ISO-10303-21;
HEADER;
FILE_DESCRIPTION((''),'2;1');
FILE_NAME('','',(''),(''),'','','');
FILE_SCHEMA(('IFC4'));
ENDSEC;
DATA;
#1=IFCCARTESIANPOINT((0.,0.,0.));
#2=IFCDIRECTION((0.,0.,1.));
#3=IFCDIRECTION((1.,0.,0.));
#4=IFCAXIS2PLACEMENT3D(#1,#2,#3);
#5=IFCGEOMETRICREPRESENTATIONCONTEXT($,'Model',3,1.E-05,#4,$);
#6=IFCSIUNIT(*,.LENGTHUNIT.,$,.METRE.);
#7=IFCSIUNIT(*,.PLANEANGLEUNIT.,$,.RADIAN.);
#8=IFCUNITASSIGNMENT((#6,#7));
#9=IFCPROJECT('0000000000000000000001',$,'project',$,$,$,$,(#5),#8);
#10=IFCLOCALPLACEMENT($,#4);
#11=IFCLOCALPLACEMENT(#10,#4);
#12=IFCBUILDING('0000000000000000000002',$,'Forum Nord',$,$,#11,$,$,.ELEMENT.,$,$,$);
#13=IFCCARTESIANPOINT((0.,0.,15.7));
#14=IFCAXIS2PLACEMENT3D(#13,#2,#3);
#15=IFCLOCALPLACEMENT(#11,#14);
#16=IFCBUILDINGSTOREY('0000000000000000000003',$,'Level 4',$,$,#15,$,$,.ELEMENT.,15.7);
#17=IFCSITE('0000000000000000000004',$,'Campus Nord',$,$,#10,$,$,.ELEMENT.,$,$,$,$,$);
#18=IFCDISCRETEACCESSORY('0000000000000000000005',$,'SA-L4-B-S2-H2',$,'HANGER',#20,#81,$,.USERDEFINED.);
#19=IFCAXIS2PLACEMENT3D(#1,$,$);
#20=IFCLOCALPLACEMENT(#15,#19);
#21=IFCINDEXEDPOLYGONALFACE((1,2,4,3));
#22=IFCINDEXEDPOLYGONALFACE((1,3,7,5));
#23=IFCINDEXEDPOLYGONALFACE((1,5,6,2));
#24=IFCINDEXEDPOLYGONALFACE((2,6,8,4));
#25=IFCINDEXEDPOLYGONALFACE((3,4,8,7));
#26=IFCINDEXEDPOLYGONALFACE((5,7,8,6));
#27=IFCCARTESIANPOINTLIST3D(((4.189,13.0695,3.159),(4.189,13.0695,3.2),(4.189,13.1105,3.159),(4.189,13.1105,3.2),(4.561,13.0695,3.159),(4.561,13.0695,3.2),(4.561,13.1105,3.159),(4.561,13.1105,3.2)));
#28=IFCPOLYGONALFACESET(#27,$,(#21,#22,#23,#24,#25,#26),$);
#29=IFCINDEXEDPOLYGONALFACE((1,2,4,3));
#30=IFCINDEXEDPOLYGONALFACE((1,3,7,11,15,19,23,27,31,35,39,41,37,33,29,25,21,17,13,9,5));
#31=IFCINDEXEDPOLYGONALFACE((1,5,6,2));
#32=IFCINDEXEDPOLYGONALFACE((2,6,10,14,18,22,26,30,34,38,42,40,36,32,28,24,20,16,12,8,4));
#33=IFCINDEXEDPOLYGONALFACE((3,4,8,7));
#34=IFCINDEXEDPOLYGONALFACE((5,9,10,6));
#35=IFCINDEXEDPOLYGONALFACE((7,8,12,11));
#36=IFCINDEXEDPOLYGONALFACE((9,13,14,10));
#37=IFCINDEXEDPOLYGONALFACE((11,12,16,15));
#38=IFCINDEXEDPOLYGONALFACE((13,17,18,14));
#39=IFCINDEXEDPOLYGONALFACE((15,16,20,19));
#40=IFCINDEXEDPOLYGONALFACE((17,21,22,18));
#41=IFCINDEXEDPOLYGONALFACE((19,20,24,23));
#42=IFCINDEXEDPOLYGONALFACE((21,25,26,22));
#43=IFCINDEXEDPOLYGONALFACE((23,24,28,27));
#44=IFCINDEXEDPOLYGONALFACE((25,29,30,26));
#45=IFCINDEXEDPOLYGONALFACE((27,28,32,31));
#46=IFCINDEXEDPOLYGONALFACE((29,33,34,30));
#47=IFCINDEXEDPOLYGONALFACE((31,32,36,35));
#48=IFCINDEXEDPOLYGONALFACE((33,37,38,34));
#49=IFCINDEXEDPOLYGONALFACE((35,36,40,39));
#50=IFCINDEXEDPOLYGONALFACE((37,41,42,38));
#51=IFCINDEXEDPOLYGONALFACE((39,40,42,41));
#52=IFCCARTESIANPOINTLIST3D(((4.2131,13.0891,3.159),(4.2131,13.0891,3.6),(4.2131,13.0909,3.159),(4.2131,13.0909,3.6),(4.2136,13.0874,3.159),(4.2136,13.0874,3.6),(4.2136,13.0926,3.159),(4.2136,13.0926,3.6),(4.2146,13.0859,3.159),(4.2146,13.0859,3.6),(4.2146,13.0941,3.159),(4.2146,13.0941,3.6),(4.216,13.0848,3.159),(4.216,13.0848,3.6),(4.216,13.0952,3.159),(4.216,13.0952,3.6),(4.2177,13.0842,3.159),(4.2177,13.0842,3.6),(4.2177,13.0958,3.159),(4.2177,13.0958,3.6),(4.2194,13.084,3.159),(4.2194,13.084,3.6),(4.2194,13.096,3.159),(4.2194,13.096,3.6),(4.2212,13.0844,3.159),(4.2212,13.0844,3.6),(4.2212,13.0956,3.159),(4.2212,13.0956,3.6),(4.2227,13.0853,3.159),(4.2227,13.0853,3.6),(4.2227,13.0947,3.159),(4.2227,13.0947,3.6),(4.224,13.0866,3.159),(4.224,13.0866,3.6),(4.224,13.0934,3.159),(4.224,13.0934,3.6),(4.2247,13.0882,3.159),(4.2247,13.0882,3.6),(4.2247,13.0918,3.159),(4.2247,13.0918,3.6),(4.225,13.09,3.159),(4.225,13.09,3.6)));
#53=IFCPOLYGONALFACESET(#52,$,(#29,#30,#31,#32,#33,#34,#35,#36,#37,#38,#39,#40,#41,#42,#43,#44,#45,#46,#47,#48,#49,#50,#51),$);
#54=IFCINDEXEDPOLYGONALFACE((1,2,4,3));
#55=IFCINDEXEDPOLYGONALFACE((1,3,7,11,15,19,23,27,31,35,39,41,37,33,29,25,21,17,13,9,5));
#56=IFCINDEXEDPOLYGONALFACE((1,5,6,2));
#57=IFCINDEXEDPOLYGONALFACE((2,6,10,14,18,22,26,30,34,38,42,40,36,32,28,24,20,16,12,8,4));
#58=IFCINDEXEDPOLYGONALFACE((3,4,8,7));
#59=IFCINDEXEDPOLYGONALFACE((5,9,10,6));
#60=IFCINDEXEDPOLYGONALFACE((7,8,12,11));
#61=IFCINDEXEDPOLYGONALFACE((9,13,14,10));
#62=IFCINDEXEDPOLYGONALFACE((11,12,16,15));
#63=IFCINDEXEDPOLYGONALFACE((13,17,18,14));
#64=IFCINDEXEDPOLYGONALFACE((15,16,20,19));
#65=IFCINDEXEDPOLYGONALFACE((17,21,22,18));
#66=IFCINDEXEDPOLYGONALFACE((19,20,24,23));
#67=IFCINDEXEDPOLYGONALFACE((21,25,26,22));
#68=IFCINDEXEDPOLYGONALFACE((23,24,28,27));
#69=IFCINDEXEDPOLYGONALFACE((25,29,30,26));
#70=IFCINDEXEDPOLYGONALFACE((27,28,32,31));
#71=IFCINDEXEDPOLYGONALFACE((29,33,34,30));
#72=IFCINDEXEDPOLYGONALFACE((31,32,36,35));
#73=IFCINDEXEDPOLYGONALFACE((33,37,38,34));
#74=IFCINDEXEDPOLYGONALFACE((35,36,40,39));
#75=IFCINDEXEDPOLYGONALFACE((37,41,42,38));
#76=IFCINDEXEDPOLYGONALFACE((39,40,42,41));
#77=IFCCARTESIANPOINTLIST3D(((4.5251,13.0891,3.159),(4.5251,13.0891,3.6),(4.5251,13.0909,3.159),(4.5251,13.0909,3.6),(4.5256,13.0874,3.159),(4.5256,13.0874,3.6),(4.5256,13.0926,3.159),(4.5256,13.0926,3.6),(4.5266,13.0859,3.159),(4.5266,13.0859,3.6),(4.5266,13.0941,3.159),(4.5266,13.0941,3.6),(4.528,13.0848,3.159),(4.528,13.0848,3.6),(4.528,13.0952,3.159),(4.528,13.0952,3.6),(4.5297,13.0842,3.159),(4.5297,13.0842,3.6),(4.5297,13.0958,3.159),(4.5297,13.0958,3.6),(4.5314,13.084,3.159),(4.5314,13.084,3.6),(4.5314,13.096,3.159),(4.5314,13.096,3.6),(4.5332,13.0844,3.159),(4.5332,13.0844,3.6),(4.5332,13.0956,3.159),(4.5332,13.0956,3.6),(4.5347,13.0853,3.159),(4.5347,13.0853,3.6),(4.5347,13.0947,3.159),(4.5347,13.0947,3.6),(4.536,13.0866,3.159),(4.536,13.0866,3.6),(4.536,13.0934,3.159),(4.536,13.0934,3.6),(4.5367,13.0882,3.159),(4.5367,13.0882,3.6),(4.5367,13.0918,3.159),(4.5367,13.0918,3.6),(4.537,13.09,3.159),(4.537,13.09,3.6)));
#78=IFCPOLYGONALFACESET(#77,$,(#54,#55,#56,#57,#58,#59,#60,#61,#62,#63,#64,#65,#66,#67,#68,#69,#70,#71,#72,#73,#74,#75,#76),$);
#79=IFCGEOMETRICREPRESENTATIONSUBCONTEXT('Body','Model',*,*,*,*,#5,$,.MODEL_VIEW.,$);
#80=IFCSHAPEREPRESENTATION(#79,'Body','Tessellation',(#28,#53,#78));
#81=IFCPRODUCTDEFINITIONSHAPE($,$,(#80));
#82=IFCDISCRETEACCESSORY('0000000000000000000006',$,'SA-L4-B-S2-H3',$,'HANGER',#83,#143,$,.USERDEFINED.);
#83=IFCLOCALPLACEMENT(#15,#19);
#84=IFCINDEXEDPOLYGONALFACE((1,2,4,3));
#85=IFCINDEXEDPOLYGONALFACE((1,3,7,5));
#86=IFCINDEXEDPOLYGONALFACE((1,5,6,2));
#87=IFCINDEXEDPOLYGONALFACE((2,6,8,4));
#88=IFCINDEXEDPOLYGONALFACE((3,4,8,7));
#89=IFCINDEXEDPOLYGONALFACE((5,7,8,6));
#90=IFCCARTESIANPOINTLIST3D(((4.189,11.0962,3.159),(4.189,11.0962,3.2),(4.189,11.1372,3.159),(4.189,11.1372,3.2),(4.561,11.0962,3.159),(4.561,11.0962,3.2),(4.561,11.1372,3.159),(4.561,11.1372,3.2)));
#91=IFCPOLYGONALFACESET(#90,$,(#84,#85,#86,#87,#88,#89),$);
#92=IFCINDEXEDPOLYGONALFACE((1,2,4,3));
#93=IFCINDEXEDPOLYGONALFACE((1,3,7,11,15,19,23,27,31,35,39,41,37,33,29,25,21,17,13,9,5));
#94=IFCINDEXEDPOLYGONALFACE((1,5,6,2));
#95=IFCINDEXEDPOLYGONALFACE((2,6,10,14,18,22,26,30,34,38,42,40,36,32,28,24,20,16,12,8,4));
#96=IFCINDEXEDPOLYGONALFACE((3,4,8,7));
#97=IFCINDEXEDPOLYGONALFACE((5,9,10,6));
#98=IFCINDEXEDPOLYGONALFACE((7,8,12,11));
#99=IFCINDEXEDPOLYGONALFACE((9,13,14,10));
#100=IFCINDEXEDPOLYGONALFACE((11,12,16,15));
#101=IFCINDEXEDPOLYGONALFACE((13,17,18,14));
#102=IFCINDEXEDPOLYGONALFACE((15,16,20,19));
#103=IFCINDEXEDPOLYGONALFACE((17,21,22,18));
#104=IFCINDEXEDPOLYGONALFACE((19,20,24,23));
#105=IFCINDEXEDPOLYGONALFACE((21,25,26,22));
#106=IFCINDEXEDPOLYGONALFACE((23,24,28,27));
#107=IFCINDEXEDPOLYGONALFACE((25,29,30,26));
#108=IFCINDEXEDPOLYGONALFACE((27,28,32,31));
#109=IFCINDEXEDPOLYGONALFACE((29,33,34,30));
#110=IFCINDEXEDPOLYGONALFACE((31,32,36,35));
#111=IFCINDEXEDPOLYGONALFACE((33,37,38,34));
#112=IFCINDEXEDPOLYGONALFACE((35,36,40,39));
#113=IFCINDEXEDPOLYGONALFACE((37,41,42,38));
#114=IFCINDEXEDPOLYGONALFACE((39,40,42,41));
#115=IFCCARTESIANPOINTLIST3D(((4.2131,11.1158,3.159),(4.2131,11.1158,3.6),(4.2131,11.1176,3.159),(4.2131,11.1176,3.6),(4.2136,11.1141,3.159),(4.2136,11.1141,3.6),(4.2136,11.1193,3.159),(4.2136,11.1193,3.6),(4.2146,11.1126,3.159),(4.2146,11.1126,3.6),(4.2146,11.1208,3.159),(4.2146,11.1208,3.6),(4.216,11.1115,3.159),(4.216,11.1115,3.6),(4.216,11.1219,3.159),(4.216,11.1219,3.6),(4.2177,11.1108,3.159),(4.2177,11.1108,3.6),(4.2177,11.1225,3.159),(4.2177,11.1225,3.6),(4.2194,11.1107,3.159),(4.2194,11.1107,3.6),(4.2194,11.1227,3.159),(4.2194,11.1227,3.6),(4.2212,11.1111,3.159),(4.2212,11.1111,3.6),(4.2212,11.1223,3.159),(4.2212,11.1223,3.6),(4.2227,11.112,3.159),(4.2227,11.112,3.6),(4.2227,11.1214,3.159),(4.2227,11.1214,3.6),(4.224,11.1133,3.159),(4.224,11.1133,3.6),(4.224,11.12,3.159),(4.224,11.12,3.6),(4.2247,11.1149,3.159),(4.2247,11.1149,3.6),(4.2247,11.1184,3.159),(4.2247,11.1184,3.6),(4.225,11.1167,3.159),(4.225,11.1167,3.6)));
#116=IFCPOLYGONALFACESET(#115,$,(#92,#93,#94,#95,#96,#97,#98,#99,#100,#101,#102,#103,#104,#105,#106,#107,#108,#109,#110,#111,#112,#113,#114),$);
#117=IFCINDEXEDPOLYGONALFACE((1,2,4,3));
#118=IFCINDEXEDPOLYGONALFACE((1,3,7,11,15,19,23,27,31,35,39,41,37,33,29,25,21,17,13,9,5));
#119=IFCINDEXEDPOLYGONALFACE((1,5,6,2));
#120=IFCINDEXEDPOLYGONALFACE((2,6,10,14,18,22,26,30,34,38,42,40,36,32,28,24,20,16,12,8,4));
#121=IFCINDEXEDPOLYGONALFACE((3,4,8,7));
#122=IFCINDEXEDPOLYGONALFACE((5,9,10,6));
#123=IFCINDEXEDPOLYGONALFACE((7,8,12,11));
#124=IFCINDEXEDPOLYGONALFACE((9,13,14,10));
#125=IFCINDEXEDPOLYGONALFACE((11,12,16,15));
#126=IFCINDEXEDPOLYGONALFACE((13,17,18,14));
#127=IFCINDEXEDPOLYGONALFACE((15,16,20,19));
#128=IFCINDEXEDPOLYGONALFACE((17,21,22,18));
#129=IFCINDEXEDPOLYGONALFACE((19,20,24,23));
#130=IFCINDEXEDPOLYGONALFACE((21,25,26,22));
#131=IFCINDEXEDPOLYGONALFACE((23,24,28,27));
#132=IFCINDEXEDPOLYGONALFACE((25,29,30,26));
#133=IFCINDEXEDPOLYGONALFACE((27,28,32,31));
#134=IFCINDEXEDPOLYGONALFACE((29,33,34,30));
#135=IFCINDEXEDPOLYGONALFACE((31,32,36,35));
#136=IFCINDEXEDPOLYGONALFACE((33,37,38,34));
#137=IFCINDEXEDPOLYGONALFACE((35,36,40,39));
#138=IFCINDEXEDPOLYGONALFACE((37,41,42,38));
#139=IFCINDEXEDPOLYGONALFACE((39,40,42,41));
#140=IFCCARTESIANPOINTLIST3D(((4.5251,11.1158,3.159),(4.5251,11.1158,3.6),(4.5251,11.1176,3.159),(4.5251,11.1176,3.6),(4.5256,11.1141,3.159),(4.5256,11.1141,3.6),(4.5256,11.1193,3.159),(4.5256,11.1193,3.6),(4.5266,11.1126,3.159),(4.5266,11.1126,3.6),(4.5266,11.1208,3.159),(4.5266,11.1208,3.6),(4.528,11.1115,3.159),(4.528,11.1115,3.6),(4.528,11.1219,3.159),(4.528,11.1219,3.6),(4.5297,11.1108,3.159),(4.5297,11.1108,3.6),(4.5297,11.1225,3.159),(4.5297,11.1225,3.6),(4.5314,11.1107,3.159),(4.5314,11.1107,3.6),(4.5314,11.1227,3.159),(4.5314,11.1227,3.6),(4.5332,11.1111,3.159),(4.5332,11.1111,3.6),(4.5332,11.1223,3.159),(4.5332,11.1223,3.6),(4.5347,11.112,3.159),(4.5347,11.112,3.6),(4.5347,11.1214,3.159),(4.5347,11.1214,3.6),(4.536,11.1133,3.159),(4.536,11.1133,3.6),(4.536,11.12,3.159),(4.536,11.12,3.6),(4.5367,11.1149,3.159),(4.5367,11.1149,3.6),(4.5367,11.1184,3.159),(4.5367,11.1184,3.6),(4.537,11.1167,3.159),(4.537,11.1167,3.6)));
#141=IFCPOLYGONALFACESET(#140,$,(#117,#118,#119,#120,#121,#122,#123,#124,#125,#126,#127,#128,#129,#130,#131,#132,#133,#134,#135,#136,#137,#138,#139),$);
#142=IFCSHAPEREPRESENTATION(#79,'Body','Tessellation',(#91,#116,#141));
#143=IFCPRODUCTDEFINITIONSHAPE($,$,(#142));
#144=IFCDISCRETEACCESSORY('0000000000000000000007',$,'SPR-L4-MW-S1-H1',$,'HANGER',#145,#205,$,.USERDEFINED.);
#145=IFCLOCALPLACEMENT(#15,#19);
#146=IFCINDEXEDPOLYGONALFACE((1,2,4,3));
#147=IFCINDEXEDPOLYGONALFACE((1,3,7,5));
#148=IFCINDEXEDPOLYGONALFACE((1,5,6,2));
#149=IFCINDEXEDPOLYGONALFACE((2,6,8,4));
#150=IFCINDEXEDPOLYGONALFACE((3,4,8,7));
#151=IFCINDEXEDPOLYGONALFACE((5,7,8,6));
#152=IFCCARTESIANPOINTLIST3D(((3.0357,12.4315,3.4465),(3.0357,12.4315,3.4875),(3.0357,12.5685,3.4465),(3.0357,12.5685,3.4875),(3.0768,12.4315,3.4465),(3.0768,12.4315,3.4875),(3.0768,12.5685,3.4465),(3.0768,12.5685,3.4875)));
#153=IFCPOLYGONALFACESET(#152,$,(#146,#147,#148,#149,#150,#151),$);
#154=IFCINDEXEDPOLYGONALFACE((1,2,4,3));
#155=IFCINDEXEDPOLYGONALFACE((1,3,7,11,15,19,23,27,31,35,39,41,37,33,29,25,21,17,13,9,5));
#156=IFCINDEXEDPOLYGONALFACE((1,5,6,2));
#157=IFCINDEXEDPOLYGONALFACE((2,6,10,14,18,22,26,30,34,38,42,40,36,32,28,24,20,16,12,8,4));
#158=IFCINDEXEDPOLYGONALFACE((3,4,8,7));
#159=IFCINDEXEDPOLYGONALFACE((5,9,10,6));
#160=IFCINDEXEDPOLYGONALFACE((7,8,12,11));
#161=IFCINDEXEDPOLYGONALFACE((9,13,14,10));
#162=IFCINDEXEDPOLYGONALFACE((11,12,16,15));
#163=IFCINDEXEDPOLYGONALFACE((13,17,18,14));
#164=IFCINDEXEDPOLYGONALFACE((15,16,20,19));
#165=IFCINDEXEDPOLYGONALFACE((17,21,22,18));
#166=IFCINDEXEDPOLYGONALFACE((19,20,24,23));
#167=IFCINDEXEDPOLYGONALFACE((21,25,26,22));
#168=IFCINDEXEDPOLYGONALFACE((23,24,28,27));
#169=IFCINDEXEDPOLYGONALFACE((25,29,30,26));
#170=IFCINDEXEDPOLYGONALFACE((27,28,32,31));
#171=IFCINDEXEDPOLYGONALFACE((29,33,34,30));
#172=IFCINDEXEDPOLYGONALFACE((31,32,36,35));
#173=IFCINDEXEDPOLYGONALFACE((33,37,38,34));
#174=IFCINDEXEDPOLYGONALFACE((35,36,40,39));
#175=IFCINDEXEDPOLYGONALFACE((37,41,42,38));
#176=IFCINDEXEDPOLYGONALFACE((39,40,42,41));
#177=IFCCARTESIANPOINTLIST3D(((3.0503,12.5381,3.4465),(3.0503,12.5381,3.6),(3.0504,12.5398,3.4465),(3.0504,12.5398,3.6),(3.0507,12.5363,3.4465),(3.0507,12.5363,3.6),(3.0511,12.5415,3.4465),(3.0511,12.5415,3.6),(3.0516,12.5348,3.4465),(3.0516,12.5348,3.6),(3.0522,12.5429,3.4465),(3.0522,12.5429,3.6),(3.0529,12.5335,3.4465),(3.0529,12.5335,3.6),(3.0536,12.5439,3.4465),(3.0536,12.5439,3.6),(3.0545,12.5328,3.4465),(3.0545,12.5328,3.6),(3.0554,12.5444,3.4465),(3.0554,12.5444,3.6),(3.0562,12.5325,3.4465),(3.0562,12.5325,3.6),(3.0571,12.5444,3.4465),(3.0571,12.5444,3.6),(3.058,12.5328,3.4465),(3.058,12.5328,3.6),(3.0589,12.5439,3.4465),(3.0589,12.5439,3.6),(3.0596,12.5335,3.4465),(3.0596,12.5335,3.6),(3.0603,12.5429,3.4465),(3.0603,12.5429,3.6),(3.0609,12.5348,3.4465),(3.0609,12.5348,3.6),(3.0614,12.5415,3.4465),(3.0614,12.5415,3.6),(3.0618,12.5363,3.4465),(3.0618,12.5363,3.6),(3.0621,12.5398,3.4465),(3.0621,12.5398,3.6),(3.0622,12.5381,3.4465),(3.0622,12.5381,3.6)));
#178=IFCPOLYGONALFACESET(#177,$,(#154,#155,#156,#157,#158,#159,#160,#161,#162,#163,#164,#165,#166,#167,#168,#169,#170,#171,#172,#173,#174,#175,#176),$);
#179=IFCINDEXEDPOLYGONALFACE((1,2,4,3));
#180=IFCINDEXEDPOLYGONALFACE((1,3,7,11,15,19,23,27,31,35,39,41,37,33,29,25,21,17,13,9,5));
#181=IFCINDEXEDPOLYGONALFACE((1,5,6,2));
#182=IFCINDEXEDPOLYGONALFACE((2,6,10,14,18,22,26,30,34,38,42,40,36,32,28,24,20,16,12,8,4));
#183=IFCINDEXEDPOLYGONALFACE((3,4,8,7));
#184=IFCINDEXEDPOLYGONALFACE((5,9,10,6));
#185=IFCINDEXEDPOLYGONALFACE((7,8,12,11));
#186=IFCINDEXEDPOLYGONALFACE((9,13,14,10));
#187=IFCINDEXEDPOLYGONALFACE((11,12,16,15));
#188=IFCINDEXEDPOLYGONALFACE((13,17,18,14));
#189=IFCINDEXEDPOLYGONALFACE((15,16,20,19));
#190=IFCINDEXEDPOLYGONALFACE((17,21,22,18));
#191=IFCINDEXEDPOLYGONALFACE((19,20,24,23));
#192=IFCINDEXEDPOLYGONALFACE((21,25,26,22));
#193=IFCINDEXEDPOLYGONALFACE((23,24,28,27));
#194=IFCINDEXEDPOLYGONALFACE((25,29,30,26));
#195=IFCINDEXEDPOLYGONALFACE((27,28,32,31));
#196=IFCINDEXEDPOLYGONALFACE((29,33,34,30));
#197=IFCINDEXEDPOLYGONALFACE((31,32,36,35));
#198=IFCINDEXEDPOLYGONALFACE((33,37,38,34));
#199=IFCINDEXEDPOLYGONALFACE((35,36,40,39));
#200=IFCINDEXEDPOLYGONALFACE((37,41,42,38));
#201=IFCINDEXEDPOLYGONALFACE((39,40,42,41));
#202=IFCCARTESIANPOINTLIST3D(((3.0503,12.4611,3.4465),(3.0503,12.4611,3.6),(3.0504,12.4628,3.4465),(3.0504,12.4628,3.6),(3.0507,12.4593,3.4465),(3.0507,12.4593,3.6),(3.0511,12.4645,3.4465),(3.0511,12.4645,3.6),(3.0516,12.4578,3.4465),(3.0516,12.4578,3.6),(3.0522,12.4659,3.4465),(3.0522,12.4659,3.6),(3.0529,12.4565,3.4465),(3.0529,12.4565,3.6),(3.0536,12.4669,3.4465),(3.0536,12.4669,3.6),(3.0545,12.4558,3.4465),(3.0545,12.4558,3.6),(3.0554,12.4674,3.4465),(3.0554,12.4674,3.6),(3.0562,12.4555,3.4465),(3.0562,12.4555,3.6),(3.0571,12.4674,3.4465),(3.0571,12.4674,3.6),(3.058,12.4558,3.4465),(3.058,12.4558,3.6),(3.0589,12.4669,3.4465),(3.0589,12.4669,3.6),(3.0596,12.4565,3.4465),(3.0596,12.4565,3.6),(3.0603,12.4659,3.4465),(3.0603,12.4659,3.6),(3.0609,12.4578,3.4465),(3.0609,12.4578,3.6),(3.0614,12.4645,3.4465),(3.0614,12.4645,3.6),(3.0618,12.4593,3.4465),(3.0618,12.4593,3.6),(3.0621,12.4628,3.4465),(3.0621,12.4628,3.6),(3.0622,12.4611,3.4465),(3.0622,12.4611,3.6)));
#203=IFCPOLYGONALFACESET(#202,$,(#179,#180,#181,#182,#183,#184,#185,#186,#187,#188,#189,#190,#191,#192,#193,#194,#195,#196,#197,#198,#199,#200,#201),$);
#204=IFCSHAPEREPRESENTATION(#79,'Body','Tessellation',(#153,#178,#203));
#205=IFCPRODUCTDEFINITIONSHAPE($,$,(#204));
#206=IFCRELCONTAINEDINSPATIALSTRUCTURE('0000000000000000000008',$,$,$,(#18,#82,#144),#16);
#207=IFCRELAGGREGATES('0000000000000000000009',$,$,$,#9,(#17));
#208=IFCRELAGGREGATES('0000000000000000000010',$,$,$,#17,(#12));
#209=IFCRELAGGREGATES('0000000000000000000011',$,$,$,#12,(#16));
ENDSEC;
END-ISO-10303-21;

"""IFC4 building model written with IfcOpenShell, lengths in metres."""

from ifc_helpers import new_model, si_unit, frame, frame_2d, origin_with_axes, origin_2d_with_axis, place, context, subcontext, project, spatial, rectangle, circle, extrude, element, save


model = new_model("IFC4")

# Units and contexts
model_context = context("Model", 3, precision=1e-05, world=origin_with_axes())
body_context = subcontext(model_context, "Body", "Model", "MODEL_VIEW")
ifc_project = project(units=[si_unit("LENGTHUNIT", "METRE"), si_unit("PLANEANGLEUNIT", "RADIAN")], contexts=[model_context])

# Site, building, storey
site_placement = place(None, origin_with_axes())
site = spatial("IfcSite", under=ifc_project, at=site_placement, Name="Campus Nord", CompositionType="ELEMENT")
building_placement = place(site_placement, origin_with_axes())
building = spatial("IfcBuilding", under=site, at=building_placement, Name="Forum Nord", CompositionType="ELEMENT")
storey_placement = place(building_placement, frame((0.0, 0.0, 15.7), z_axis=(0.0, 0.0, 1.0), x_axis=(1.0, 0.0, 0.0)))
storey = spatial("IfcBuildingStorey", under=building, at=storey_placement, Name="Level 4", CompositionType="ELEMENT", Elevation=15.7)

# Discrete accessories
for number, where, z_axis, x_axis, name in (
    (1, (4.375, 13.09, 3.2), (0.0, 0.0, 1.0), (1.0, 0.0, 0.0), "SA-L4-B-S2-H2"),
    (2, (4.375, 11.1167, 3.2), (0.0, 0.0, 1.0), (1.0, 0.0, 0.0), "SA-L4-B-S2-H3"),
):
    element("IfcDiscreteAccessory", number, at=place(storey_placement, frame(where, z_axis=z_axis, x_axis=x_axis)), inside=storey, Name=name, ObjectType="HANGER", PredefinedType="USERDEFINED", context=body_context, shape_type="SweptSolid", body=[
        extrude(rectangle(XDim=0.372, YDim=0.041, at=origin_2d_with_axis()), frame((0.0, 0.0, -0.041), z_axis=(0.0, 0.0, 1.0), x_axis=(1.0, 0.0, 0.0)), (0.0, 0.0, 1.0), 0.041),
        extrude(circle(Radius=0.006, at=frame_2d((-0.156, 0.0), x_axis=(1.0, 0.0))), frame((0.0, 0.0, -0.041), z_axis=(0.0, 0.0, 1.0), x_axis=(1.0, 0.0, 0.0)), (0.0, 0.0, 1.0), 0.441),
        extrude(circle(Radius=0.006, at=frame_2d((0.156, 0.0), x_axis=(1.0, 0.0))), frame((0.0, 0.0, -0.041), z_axis=(0.0, 0.0, 1.0), x_axis=(1.0, 0.0, 0.0)), (0.0, 0.0, 1.0), 0.441),
    ])
for number, where, z_axis, x_axis, name in (
    (3, (3.0562, 12.5, 3.4875), (0.0, 0.0, 1.0), (0.0, -1.0, 0.0), "SPR-L4-MW-S1-H1"),
):
    element("IfcDiscreteAccessory", number, at=place(storey_placement, frame(where, z_axis=z_axis, x_axis=x_axis)), inside=storey, Name=name, ObjectType="HANGER", PredefinedType="USERDEFINED", context=body_context, shape_type="SweptSolid", body=[
        extrude(rectangle(XDim=0.137, YDim=0.041, at=origin_2d_with_axis()), frame((0.0, 0.0, -0.041), z_axis=(0.0, 0.0, 1.0), x_axis=(1.0, 0.0, 0.0)), (0.0, 0.0, 1.0), 0.041),
        extrude(circle(Radius=0.006, at=frame_2d((-0.0385, 0.0), x_axis=(1.0, 0.0))), frame((0.0, 0.0, -0.041), z_axis=(0.0, 0.0, 1.0), x_axis=(1.0, 0.0, 0.0)), (0.0, 0.0, 1.0), 0.1535),
        extrude(circle(Radius=0.006, at=frame_2d((0.0385, 0.0), x_axis=(1.0, 0.0))), frame((0.0, 0.0, -0.041), z_axis=(0.0, 0.0, 1.0), x_axis=(1.0, 0.0, 0.0)), (0.0, 0.0, 1.0), 0.1535),
    ])

save(model, "model.ifc")
